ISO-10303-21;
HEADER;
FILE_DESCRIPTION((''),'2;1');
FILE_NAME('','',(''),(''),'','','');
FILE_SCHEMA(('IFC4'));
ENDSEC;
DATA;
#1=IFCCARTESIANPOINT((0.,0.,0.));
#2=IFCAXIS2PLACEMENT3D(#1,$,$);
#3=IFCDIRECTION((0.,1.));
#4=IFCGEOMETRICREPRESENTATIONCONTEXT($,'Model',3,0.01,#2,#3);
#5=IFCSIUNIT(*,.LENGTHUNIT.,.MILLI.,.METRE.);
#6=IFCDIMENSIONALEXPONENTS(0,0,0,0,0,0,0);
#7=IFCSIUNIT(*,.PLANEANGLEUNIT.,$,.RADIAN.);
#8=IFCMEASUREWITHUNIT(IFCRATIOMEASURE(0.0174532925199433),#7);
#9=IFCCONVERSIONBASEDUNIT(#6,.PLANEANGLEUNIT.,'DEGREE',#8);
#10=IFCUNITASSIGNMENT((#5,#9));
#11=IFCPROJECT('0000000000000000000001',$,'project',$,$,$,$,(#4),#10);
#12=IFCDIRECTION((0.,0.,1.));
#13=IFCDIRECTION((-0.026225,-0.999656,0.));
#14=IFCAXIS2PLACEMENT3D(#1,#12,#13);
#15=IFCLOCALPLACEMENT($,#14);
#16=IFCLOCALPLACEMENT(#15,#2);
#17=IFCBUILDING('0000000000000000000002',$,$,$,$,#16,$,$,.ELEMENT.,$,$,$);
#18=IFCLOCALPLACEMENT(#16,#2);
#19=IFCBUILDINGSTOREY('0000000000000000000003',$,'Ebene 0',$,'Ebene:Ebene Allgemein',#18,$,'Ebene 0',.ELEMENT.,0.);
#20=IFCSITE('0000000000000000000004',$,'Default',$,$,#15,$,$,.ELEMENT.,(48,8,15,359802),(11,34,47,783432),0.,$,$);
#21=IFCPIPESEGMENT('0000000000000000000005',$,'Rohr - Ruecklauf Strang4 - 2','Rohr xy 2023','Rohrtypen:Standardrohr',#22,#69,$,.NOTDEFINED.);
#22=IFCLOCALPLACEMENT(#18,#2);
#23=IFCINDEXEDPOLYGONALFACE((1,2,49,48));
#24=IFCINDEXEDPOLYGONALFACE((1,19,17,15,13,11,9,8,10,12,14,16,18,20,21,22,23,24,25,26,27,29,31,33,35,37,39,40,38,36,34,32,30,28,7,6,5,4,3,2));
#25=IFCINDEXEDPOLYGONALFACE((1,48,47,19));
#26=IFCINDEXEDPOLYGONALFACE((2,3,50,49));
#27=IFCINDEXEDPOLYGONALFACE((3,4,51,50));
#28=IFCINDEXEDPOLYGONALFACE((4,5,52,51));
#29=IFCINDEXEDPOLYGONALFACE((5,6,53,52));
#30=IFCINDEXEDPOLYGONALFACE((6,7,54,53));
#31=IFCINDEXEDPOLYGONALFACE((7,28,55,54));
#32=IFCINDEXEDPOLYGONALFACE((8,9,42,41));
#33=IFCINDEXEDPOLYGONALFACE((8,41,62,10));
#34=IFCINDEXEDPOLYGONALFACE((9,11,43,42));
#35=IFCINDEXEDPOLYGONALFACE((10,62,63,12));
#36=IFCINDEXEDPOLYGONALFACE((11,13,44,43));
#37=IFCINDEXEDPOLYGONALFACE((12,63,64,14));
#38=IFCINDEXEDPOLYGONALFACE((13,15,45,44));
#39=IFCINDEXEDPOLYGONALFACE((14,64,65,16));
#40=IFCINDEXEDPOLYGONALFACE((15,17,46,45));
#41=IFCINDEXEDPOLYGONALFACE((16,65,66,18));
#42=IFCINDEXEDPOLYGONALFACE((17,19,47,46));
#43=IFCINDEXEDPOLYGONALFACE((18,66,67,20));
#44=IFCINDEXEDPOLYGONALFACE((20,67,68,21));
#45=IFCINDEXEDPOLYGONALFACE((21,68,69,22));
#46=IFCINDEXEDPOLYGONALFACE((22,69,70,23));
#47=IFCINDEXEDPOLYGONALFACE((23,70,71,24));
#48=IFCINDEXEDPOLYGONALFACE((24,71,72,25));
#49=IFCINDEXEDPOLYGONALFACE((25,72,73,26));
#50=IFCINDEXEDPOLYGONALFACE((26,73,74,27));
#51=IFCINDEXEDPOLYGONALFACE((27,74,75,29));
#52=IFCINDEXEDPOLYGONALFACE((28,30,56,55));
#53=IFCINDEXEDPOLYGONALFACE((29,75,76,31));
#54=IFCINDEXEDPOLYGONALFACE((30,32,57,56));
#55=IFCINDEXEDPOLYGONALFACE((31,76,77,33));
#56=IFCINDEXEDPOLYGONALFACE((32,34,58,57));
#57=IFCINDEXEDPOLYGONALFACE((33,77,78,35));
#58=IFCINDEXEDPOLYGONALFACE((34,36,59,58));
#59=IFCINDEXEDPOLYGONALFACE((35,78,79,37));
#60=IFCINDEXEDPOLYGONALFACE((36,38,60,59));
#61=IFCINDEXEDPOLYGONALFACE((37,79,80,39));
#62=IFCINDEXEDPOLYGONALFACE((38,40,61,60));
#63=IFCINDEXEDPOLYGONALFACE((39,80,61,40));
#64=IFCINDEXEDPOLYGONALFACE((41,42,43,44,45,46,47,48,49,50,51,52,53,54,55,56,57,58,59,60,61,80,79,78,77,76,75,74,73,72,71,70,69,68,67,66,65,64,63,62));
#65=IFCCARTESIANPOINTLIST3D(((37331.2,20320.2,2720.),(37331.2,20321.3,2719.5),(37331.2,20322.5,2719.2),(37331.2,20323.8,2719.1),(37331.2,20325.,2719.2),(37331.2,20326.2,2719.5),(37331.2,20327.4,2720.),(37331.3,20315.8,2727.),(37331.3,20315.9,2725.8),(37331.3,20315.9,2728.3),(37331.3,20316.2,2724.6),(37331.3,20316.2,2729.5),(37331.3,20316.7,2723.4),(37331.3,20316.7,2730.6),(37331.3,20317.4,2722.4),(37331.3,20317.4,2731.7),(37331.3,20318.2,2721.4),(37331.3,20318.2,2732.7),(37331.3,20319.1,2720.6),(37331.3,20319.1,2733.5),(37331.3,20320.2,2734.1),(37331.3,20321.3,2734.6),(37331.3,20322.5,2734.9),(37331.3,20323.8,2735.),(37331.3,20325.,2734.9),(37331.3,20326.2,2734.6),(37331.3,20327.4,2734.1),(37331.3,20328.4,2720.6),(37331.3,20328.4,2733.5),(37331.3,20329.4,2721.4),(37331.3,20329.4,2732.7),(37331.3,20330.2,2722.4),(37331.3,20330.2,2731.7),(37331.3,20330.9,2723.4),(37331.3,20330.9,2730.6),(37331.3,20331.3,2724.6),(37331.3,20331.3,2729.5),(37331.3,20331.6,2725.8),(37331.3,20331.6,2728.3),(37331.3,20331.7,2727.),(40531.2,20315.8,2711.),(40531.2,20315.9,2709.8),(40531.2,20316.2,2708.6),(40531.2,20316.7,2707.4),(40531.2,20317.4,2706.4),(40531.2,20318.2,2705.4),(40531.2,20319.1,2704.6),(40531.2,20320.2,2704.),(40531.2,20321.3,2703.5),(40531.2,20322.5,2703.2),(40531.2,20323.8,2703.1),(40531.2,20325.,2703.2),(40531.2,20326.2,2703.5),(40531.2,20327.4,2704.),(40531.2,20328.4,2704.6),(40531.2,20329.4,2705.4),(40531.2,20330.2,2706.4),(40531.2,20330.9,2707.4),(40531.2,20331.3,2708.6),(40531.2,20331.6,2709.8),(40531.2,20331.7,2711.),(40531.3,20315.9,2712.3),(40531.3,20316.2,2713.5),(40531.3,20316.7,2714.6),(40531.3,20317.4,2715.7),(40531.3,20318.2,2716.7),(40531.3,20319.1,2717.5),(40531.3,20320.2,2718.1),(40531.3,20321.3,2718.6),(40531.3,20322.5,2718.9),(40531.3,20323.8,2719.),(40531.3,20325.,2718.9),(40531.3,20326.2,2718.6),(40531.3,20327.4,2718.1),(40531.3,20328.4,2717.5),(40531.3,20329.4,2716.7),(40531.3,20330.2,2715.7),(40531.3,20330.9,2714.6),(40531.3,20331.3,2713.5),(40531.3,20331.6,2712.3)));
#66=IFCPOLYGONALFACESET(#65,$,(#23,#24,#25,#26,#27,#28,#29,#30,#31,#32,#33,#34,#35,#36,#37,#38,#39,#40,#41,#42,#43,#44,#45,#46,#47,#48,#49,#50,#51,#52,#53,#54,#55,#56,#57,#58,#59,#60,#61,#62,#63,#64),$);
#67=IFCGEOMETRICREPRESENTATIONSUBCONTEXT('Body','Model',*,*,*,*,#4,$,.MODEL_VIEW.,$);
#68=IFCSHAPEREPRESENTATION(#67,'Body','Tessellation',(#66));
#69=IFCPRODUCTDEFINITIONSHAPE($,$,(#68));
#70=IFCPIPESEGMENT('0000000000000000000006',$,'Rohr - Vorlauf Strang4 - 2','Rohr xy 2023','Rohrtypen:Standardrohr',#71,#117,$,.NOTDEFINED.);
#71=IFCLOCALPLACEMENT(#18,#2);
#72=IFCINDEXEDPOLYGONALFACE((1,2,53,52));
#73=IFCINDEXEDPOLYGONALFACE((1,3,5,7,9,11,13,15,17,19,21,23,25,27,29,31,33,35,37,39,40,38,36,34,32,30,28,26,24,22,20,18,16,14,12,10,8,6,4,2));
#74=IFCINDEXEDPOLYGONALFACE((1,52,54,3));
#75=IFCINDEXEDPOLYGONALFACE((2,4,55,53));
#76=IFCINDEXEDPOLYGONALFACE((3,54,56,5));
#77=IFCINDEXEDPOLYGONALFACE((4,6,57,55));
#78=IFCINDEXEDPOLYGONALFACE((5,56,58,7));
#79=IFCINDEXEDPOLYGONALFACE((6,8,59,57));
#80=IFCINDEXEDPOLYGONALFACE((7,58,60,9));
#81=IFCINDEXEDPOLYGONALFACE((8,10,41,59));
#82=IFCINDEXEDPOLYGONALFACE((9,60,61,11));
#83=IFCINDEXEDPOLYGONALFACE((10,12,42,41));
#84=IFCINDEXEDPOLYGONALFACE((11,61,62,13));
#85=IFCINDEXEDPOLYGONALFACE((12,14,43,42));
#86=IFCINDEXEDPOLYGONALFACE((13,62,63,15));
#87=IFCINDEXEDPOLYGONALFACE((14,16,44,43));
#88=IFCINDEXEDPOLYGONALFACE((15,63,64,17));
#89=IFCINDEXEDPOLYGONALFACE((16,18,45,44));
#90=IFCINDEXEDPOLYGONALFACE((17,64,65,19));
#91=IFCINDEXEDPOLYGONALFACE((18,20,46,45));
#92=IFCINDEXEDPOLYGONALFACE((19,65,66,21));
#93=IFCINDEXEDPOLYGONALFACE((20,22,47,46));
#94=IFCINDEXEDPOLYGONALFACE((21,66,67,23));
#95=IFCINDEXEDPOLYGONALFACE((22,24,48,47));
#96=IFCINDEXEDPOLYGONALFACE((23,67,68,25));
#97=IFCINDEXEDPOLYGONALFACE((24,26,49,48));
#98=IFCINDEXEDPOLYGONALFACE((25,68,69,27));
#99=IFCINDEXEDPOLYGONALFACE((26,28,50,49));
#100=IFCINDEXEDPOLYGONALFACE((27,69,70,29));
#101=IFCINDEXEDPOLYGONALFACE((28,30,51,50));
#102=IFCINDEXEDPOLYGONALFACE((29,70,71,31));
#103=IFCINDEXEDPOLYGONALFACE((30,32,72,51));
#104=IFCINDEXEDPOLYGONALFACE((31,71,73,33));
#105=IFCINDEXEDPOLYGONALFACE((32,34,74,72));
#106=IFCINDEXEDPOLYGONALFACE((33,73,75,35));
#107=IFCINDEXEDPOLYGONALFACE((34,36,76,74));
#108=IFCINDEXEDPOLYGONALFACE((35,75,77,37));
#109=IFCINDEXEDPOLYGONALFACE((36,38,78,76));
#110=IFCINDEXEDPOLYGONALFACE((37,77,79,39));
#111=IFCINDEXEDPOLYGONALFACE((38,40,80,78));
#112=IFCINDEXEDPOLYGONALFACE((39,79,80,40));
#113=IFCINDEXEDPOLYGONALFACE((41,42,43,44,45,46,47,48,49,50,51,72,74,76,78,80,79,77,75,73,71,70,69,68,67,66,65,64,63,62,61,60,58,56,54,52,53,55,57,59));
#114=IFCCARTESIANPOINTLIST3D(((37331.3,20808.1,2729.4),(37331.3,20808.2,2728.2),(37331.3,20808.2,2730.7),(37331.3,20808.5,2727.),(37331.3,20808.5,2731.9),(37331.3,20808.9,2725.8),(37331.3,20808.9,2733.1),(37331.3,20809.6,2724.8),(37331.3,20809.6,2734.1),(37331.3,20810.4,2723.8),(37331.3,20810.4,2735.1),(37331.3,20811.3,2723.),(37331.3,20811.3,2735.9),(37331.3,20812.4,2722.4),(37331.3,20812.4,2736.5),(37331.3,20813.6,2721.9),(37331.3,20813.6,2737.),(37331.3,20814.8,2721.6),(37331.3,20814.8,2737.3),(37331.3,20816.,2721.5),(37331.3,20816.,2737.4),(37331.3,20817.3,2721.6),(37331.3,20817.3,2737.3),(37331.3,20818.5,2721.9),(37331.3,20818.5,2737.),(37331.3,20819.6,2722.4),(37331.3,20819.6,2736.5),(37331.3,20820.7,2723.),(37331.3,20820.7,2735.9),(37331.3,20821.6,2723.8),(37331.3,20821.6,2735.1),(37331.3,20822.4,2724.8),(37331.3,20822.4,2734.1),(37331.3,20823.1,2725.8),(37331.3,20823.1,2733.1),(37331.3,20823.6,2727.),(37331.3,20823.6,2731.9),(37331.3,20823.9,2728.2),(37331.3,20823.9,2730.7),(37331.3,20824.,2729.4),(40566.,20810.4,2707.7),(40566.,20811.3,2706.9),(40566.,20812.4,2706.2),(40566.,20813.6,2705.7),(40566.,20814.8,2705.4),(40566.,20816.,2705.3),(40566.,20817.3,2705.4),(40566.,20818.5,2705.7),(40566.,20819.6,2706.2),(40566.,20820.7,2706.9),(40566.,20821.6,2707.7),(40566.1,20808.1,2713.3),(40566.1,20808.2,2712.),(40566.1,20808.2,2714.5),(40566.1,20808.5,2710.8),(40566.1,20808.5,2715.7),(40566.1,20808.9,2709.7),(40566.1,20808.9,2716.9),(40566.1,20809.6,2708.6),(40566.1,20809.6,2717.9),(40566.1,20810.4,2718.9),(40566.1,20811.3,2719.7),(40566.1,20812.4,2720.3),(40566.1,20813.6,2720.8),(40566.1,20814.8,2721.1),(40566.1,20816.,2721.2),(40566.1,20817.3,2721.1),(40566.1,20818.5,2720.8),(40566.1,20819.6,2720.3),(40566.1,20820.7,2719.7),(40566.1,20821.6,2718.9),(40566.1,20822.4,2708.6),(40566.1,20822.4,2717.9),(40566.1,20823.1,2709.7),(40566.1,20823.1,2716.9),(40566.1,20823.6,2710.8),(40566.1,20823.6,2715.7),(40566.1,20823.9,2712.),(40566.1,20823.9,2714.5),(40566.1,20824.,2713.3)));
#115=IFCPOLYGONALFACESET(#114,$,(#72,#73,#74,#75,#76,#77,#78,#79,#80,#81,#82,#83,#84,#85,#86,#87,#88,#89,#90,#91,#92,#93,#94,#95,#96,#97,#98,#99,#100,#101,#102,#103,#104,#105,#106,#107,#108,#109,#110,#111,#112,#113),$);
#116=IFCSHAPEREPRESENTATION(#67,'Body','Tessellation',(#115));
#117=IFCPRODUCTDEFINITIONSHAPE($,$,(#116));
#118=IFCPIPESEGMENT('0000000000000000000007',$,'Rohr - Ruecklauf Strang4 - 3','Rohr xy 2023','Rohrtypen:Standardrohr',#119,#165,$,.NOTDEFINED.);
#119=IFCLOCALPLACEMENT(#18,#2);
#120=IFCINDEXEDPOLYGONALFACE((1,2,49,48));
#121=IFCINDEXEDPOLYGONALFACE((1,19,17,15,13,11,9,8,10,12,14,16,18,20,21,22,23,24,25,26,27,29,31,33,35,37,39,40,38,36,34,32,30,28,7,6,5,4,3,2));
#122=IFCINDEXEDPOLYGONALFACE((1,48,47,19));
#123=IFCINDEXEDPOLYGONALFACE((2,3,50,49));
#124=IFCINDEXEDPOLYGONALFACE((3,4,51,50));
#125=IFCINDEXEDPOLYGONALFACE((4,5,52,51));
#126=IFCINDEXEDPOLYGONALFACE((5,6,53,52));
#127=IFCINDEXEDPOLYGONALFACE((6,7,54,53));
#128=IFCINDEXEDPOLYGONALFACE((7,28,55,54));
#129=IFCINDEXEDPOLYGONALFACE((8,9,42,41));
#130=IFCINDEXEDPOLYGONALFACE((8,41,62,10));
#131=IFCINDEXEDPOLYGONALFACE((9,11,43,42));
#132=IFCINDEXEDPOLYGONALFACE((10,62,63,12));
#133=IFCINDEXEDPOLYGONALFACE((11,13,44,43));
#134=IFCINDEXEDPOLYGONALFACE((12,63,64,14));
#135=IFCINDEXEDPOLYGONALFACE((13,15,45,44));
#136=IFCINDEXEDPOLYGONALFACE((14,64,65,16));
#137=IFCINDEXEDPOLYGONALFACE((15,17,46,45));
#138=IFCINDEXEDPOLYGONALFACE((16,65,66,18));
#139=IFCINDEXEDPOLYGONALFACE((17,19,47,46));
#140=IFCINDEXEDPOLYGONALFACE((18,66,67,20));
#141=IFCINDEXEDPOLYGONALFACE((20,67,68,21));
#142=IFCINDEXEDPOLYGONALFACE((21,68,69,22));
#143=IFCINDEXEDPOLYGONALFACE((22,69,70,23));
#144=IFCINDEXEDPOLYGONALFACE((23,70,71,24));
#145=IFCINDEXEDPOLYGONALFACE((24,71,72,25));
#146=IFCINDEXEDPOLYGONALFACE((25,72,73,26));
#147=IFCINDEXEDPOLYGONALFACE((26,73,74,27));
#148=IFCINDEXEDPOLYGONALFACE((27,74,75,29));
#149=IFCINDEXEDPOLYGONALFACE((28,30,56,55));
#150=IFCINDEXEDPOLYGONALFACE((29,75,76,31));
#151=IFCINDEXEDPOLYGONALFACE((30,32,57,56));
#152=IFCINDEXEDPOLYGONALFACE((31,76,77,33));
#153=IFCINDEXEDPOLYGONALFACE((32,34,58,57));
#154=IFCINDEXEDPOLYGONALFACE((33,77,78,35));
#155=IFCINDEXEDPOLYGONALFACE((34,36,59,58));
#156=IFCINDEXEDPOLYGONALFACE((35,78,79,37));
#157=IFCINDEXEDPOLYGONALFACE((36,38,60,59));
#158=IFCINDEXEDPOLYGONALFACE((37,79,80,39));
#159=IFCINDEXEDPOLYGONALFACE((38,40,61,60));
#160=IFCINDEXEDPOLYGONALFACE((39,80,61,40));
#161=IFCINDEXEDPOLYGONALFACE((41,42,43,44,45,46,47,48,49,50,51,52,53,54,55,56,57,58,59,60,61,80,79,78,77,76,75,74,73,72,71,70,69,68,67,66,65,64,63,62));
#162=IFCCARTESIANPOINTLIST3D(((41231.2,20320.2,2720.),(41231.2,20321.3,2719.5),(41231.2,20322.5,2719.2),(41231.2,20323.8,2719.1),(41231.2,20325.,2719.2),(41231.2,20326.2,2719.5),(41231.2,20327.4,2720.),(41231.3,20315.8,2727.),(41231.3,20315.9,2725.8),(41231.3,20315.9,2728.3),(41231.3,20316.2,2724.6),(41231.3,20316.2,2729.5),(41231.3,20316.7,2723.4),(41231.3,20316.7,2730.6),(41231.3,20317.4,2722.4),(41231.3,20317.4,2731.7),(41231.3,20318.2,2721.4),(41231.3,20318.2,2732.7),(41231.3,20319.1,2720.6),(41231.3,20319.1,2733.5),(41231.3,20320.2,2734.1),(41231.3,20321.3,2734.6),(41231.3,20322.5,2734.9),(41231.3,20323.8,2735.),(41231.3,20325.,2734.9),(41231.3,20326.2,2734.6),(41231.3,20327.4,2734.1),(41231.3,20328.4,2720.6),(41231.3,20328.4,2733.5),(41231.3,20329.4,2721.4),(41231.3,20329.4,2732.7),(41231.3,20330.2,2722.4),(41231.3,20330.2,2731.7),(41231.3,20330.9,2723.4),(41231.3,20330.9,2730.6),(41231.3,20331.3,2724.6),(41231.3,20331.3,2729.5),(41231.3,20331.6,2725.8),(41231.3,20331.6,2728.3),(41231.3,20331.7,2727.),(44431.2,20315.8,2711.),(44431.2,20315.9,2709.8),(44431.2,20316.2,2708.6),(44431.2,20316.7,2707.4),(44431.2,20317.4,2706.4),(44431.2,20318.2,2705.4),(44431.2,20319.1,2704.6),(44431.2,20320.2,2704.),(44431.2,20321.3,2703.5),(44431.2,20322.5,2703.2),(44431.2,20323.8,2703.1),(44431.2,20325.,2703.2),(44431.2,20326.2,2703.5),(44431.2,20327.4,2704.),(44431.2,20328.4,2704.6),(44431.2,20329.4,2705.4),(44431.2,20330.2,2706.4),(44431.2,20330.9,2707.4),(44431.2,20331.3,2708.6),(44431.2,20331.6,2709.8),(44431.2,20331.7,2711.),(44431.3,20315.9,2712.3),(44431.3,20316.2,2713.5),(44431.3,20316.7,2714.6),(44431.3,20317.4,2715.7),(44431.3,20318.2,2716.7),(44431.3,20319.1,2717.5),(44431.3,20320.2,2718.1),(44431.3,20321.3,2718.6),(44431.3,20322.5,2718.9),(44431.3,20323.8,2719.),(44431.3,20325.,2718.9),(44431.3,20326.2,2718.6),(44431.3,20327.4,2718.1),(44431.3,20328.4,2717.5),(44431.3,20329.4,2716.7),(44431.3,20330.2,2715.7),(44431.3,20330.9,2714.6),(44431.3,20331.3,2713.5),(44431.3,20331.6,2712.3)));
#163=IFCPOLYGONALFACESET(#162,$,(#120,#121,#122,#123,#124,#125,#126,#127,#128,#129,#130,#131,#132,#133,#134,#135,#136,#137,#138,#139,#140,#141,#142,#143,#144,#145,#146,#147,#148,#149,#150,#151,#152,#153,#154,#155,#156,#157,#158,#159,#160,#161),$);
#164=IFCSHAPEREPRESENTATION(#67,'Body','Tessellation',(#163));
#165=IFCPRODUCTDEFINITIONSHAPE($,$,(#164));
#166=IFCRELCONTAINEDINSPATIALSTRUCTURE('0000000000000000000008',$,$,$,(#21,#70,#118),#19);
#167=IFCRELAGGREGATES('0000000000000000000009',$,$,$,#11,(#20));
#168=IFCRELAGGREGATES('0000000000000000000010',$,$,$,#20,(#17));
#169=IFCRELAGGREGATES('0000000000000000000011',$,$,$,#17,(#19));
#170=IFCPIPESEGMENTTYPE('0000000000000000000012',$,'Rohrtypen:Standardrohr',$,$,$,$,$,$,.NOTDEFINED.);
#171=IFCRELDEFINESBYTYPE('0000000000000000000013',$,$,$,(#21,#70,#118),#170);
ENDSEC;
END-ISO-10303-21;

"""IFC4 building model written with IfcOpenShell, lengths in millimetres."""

from ifc_helpers import new_model, entity, si_unit, converted_unit, direction, frame, origin, place, context, subcontext, project, spatial, indexed_curve, outline, extrude, type_object, element, save


model = new_model("IFC4")

# Units and contexts
model_context = context("Model", 3, precision=0.01, world=origin(), true_north=direction((0.0, 1.0)))
body_context = subcontext(model_context, "Body", "Model", "MODEL_VIEW")
ifc_project = project(units=[si_unit("LENGTHUNIT", "METRE", prefix="MILLI"), converted_unit("PLANEANGLEUNIT", "DEGREE", entity("IfcRatioMeasure", 0.0174532925199433), si_unit("PLANEANGLEUNIT", "RADIAN"), dimensions=[0, 0, 0, 0, 0, 0, 0])], contexts=[model_context])

# Site, building, storey
site_placement = place(None, frame((0.0, 0.0, 0.0), z_axis=(0.0, 0.0, 1.0), x_axis=(-0.026225, -0.999656, 0.0)))
site = spatial("IfcSite", under=ifc_project, at=site_placement, Name="Default", CompositionType="ELEMENT", RefLatitude=(48, 8, 15, 359802), RefLongitude=(11, 34, 47, 783432), RefElevation=0.0)
building_placement = place(site_placement, origin())
building = spatial("IfcBuilding", under=site, at=building_placement, CompositionType="ELEMENT")
storey_placement = place(building_placement, origin())
storey = spatial("IfcBuildingStorey", under=building, at=storey_placement, Name="Ebene 0", ObjectType="Ebene:Ebene Allgemein", LongName="Ebene 0", CompositionType="ELEMENT", Elevation=0.0)

# Pipe segments
pipe_segment_type = type_object("IfcPipeSegmentType", Name="Rohrtypen:Standardrohr", PredefinedType="NOTDEFINED")
pipe_segment_1_placement = place(storey_placement, origin())
element("IfcPipeSegment", 1, at=pipe_segment_1_placement, inside=storey, type_object=pipe_segment_type, Name="Rohr - Ruecklauf Strang4 - 2", Description="Rohr xy 2023", ObjectType="Rohrtypen:Standardrohr", PredefinedType="NOTDEFINED", context=body_context, shape_type="SweptSolid", body=[
    extrude(outline(indexed_curve([(7.9, 0.0), (7.8, 1.2), (7.6, 2.5), (7.1, 3.6), (6.4, 4.7), (5.6, 5.6), (4.7, 6.4), (3.6, 7.1), (2.5, 7.6), (1.2, 7.8), (0.0, 7.9), (-1.2, 7.8), (-2.5, 7.6), (-3.6, 7.1), (-4.7, 6.4), (-5.6, 5.6), (-6.4, 4.7), (-7.1, 3.6), (-7.6, 2.5), (-7.8, 1.2), (-7.9, 0.0), (-7.8, -1.2), (-7.6, -2.5), (-7.1, -3.6), (-6.4, -4.7), (-5.6, -5.6), (-4.7, -6.4), (-3.6, -7.1), (-2.5, -7.6), (-1.2, -7.8), (0.0, -7.9), (1.2, -7.8), (2.5, -7.6), (3.6, -7.1), (4.7, -6.4), (5.6, -5.6), (6.4, -4.7), (7.1, -3.6), (7.6, -2.5), (7.8, -1.2), (7.9, 0.0)], self_intersect=False)), frame((40531.2, 20323.8, 2711.0), z_axis=(-0.999988, 0.0, 0.005), x_axis=(0.0, 1.0, 0.0)), (0.0, 0.0, 1.0), 3200.0),
])
pipe_segment_2_placement = place(storey_placement, origin())
element("IfcPipeSegment", 2, at=pipe_segment_2_placement, inside=storey, type_object=pipe_segment_type, Name="Rohr - Vorlauf Strang4 - 2", Description="Rohr xy 2023", ObjectType="Rohrtypen:Standardrohr", PredefinedType="NOTDEFINED", context=body_context, shape_type="SweptSolid", body=[
    extrude(outline(indexed_curve([(7.9, 0.0), (7.8, 1.2), (7.6, 2.5), (7.1, 3.6), (6.4, 4.7), (5.6, 5.6), (4.7, 6.4), (3.6, 7.1), (2.5, 7.6), (1.2, 7.8), (0.0, 7.9), (-1.2, 7.8), (-2.5, 7.6), (-3.6, 7.1), (-4.7, 6.4), (-5.6, 5.6), (-6.4, 4.7), (-7.1, 3.6), (-7.6, 2.5), (-7.8, 1.2), (-7.9, 0.0), (-7.8, -1.2), (-7.6, -2.5), (-7.1, -3.6), (-6.4, -4.7), (-5.6, -5.6), (-4.7, -6.4), (-3.6, -7.1), (-2.5, -7.6), (-1.2, -7.8), (0.0, -7.9), (1.2, -7.8), (2.5, -7.6), (3.6, -7.1), (4.7, -6.4), (5.6, -5.6), (6.4, -4.7), (7.1, -3.6), (7.6, -2.5), (7.8, -1.2), (7.9, 0.0)], self_intersect=False)), frame((40566.1, 20816.0, 2713.3), z_axis=(-0.999988, 0.0, 0.005), x_axis=(0.0, 1.0, 0.0)), (0.0, 0.0, 1.0), 3234.8),
])
pipe_segment_3_placement = place(storey_placement, origin())
element("IfcPipeSegment", 3, at=pipe_segment_3_placement, inside=storey, type_object=pipe_segment_type, Name="Rohr - Ruecklauf Strang4 - 3", Description="Rohr xy 2023", ObjectType="Rohrtypen:Standardrohr", PredefinedType="NOTDEFINED", context=body_context, shape_type="SweptSolid", body=[
    extrude(outline(indexed_curve([(7.9, 0.0), (7.8, 1.2), (7.6, 2.5), (7.1, 3.6), (6.4, 4.7), (5.6, 5.6), (4.7, 6.4), (3.6, 7.1), (2.5, 7.6), (1.2, 7.8), (0.0, 7.9), (-1.2, 7.8), (-2.5, 7.6), (-3.6, 7.1), (-4.7, 6.4), (-5.6, 5.6), (-6.4, 4.7), (-7.1, 3.6), (-7.6, 2.5), (-7.8, 1.2), (-7.9, 0.0), (-7.8, -1.2), (-7.6, -2.5), (-7.1, -3.6), (-6.4, -4.7), (-5.6, -5.6), (-4.7, -6.4), (-3.6, -7.1), (-2.5, -7.6), (-1.2, -7.8), (0.0, -7.9), (1.2, -7.8), (2.5, -7.6), (3.6, -7.1), (4.7, -6.4), (5.6, -5.6), (6.4, -4.7), (7.1, -3.6), (7.6, -2.5), (7.8, -1.2), (7.9, 0.0)], self_intersect=False)), frame((44431.2, 20323.8, 2711.0), z_axis=(-0.999988, 0.0, 0.005), x_axis=(0.0, 1.0, 0.0)), (0.0, 0.0, 1.0), 3200.0),
])

save(model, "model.ifc")
